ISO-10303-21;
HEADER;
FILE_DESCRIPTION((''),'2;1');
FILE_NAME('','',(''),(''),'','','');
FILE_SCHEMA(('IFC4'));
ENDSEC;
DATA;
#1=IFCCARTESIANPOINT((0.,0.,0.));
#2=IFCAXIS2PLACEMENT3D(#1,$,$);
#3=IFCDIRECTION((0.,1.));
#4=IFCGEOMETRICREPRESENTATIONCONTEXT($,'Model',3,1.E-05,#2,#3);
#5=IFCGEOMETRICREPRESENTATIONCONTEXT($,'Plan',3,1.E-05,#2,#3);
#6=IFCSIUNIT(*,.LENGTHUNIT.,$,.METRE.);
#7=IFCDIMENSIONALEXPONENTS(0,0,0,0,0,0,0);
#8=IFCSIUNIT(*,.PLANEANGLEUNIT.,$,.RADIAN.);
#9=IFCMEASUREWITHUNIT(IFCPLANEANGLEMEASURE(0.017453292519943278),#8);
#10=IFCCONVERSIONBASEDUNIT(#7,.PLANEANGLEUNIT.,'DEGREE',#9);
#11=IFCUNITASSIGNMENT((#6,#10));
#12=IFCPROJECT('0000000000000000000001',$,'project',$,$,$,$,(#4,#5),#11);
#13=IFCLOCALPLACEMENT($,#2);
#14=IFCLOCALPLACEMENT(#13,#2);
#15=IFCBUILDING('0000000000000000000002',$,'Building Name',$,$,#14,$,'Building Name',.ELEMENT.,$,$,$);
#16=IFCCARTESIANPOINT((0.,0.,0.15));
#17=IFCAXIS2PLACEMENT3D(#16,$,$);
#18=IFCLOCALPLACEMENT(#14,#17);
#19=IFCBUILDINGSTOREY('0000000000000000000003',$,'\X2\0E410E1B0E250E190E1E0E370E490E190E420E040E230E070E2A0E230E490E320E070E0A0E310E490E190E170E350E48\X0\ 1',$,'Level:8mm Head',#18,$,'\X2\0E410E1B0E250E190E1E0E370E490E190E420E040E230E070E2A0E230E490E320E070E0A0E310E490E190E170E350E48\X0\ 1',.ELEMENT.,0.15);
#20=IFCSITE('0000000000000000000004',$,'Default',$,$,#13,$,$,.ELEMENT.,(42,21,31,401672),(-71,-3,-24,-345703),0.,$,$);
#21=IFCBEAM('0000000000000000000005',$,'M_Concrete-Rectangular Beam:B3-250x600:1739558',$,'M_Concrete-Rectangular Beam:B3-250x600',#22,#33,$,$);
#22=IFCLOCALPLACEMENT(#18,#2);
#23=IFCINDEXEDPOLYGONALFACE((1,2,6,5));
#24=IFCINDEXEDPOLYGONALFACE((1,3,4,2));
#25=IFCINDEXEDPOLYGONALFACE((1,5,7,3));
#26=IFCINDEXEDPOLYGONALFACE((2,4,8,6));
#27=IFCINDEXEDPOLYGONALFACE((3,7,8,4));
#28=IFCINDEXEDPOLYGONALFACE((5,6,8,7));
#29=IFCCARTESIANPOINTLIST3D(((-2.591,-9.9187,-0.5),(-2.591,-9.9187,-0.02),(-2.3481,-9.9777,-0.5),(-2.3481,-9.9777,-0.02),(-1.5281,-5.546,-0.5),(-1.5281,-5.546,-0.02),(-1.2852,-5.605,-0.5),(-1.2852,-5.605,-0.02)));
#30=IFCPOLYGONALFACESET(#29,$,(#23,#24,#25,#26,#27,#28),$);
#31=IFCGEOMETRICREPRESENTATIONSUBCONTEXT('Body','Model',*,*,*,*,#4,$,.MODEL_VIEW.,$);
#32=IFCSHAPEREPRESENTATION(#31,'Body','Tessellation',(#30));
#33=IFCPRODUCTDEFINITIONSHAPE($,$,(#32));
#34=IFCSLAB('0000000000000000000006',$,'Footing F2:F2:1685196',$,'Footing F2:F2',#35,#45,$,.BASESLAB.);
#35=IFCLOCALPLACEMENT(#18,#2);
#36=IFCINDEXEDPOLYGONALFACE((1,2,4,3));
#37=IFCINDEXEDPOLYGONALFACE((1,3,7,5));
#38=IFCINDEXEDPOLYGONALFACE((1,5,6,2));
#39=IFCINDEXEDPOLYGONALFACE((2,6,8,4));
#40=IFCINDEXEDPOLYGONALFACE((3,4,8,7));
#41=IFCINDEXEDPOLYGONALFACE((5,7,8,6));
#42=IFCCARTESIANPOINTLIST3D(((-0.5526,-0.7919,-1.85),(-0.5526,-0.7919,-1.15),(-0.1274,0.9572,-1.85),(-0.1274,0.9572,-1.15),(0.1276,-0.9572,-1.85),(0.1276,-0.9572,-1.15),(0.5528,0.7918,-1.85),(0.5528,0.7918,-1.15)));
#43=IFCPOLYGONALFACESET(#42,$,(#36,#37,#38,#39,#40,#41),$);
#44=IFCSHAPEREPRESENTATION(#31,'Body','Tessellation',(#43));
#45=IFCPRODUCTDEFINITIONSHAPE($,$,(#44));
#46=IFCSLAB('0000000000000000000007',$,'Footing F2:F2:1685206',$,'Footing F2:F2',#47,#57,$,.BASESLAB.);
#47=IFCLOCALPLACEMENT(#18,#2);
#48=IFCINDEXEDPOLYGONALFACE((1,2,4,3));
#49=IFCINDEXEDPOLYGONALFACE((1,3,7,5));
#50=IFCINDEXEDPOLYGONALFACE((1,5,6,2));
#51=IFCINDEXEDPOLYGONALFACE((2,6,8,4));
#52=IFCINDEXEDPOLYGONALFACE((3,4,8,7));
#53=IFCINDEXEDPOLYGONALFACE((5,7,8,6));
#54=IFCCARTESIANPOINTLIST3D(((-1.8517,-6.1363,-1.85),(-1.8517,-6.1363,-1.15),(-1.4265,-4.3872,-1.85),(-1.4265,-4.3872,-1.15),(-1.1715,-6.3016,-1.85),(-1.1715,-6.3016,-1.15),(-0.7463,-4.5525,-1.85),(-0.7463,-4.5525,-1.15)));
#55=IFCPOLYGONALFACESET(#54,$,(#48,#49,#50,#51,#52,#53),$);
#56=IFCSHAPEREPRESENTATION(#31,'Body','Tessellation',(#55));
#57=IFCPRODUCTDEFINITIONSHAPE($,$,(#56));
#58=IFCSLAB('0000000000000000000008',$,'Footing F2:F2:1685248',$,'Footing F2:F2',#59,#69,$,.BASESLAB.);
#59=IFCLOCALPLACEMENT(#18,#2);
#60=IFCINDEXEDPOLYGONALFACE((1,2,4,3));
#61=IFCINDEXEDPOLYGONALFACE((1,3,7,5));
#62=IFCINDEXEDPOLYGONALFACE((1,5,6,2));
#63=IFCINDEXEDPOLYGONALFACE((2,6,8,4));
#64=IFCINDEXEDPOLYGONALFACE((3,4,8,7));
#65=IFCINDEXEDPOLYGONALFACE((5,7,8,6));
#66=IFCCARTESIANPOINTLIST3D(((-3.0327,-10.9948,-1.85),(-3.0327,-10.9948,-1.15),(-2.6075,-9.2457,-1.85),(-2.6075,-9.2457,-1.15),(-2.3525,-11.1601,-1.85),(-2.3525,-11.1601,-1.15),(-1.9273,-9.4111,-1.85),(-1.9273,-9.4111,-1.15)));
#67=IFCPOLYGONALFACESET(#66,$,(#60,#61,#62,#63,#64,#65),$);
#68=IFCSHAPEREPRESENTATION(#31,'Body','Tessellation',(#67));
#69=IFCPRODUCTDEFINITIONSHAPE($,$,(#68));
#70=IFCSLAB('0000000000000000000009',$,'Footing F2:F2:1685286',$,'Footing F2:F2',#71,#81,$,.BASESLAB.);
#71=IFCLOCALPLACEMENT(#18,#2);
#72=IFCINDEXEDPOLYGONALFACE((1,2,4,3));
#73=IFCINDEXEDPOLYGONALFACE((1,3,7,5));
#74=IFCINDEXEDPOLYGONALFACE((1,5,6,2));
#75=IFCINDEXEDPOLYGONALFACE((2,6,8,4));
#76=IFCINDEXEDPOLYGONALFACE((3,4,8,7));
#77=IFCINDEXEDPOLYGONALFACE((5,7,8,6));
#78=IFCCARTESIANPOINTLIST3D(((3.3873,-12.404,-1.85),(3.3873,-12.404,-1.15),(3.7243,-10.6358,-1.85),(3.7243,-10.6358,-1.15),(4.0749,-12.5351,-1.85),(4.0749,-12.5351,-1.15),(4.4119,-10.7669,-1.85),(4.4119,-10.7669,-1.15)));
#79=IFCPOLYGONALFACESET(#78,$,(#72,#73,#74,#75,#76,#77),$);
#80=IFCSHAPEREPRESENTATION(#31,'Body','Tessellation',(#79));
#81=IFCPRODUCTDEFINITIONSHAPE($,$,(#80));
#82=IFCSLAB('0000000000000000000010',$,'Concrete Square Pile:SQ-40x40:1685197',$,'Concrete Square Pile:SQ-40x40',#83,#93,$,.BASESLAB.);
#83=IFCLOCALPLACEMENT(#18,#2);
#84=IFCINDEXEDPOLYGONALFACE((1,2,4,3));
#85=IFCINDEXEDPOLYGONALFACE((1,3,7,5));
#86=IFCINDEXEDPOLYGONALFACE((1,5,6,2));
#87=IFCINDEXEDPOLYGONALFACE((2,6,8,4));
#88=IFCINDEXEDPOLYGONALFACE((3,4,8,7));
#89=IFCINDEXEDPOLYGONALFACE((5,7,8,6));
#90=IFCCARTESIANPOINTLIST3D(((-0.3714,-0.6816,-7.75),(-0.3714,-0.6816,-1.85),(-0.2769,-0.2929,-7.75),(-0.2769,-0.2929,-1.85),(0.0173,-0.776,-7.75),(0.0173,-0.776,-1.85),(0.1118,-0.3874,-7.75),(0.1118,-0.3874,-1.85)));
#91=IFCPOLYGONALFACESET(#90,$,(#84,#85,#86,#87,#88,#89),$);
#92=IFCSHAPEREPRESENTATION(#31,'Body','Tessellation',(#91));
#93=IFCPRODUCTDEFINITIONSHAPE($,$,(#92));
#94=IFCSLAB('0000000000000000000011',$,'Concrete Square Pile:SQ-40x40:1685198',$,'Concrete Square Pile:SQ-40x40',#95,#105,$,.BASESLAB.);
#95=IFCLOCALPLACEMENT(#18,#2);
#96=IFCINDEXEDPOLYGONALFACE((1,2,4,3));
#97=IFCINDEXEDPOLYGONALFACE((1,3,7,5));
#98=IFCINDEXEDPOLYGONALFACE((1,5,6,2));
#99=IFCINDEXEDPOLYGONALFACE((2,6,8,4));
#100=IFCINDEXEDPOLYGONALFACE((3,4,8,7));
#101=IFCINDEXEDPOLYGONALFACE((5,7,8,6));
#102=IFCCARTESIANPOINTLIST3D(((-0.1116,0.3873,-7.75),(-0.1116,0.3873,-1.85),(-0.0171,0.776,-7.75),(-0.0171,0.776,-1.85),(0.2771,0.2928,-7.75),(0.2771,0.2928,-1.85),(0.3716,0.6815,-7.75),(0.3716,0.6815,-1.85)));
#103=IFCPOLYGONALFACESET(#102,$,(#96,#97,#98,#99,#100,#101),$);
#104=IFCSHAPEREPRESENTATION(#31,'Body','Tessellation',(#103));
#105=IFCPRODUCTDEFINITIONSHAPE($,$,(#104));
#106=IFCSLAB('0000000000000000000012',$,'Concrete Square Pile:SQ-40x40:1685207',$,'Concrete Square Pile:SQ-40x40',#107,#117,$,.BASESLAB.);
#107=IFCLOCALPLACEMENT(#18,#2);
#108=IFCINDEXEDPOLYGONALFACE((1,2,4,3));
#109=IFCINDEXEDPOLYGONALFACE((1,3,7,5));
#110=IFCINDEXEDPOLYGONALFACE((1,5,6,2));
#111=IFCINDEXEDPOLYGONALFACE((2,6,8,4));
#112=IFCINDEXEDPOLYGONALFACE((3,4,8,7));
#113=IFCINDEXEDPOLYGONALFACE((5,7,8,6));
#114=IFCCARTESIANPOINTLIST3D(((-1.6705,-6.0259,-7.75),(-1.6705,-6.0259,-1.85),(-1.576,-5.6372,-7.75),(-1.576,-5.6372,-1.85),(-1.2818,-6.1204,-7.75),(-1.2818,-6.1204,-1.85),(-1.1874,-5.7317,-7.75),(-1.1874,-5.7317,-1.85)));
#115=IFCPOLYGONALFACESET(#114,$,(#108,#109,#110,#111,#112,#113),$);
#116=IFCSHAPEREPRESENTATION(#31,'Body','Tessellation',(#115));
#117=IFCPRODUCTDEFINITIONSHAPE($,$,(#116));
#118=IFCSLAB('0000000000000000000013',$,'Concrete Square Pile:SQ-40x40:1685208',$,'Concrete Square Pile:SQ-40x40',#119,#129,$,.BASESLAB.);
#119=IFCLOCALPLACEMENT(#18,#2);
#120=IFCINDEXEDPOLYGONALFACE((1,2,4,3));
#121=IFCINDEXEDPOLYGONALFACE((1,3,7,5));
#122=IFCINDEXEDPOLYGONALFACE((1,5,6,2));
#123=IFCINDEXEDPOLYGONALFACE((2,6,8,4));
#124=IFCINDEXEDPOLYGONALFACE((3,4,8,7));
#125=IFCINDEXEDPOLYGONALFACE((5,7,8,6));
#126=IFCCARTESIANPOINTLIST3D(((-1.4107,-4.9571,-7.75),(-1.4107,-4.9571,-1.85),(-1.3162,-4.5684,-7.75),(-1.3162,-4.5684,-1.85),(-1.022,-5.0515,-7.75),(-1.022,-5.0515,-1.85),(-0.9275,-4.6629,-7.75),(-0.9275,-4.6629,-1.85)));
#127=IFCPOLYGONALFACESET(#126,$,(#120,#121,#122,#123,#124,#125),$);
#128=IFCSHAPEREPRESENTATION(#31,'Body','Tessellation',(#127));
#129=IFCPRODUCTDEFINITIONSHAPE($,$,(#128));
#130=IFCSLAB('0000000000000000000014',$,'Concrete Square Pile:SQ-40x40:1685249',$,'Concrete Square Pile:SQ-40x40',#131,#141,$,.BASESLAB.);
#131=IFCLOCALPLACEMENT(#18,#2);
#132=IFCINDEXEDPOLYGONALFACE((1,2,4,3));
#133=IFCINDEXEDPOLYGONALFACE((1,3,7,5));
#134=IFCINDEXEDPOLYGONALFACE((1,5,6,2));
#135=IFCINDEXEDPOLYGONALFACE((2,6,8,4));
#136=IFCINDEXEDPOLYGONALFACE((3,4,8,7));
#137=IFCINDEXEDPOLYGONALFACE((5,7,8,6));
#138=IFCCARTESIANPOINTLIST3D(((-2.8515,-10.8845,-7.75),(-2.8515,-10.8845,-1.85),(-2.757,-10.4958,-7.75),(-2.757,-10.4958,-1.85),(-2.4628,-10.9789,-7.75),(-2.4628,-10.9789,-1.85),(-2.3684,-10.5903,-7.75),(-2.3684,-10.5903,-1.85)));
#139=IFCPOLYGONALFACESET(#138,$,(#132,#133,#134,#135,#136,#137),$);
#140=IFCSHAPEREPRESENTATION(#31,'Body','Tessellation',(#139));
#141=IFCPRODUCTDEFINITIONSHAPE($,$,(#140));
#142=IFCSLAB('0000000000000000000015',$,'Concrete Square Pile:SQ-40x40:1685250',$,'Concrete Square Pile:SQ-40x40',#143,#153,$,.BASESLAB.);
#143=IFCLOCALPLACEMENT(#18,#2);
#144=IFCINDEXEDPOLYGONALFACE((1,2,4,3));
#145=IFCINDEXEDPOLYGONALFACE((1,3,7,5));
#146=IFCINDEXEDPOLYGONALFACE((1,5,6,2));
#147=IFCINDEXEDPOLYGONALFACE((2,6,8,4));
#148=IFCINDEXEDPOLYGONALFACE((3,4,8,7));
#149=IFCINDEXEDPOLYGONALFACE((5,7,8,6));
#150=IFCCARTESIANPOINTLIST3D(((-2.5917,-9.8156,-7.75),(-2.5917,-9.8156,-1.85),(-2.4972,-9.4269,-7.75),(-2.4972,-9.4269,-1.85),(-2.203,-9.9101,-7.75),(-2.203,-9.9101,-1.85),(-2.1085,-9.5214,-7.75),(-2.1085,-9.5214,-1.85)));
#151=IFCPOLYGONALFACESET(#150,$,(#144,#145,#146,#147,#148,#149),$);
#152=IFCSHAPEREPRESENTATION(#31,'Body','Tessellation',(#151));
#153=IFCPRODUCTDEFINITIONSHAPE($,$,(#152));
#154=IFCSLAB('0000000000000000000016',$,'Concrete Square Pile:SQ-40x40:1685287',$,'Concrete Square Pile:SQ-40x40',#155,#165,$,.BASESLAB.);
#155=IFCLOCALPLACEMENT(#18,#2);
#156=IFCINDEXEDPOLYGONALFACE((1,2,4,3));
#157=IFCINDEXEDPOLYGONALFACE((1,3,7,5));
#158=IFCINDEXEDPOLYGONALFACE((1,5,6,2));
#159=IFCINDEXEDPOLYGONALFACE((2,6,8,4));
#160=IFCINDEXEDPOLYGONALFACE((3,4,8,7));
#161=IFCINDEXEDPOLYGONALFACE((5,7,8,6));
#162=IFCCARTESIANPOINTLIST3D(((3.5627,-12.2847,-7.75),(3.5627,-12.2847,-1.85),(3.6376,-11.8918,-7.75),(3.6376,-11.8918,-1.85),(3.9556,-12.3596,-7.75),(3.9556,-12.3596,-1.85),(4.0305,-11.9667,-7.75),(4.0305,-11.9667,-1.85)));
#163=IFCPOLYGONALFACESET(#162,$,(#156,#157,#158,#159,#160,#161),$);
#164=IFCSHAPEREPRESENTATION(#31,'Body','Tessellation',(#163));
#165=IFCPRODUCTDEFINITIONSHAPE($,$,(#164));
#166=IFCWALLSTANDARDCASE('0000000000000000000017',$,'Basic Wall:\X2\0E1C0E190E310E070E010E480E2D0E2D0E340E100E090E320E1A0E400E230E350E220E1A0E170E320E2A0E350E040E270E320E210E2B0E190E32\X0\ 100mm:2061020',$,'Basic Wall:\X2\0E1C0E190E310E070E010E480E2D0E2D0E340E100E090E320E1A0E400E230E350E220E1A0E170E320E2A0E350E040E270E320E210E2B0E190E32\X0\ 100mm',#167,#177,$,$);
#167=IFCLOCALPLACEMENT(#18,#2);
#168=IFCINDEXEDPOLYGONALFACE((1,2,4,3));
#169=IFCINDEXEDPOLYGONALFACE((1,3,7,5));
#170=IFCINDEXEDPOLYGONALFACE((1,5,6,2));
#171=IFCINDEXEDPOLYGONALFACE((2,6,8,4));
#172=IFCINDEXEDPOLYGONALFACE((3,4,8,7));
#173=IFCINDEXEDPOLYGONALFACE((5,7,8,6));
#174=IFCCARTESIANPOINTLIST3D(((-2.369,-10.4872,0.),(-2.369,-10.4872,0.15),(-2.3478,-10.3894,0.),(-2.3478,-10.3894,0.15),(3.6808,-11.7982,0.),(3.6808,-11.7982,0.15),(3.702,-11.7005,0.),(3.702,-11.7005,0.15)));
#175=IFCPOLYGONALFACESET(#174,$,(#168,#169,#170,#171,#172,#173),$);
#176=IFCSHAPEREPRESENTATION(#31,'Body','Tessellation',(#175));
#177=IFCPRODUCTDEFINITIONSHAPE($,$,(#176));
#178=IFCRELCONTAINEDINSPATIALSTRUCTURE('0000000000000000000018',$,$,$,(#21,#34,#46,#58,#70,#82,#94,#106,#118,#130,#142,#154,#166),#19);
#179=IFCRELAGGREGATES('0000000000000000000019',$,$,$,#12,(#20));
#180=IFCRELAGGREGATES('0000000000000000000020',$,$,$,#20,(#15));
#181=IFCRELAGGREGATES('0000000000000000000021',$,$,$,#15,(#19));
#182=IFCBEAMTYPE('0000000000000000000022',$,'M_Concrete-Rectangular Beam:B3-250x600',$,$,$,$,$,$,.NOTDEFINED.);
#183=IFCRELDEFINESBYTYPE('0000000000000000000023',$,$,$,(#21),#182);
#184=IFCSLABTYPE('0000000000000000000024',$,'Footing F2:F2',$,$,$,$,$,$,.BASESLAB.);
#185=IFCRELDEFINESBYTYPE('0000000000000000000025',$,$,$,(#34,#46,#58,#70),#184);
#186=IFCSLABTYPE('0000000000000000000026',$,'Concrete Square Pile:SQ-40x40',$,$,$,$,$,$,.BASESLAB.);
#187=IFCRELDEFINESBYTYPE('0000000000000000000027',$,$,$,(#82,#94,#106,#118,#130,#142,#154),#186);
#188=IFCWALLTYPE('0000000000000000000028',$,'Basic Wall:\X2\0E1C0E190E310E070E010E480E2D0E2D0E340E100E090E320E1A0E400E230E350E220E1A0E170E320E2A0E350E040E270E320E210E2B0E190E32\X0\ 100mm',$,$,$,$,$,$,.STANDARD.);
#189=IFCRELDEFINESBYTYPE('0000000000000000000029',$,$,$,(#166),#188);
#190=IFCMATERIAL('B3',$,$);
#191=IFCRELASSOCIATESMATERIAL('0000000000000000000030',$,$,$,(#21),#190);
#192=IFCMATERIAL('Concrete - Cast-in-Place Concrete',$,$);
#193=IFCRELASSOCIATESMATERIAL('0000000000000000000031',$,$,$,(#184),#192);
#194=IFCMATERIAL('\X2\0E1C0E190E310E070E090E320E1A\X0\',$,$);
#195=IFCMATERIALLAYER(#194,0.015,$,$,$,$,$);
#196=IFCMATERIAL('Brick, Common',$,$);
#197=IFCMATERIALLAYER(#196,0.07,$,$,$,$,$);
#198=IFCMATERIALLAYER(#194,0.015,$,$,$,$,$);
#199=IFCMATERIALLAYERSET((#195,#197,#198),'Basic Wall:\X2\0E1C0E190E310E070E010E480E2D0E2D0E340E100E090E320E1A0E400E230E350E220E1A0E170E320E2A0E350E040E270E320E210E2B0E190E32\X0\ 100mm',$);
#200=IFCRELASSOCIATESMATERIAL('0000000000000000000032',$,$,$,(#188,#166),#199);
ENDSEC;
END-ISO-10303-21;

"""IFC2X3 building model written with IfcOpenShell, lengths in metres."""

from ifc_helpers import new_model, entity, si_unit, converted_unit, direction, frame, frame_2d, origin, origin_2d_with_axis, place, context, subcontext, project, spatial, rectangle, extrude, clip, halfspace, material, layer, layer_set, layer_usage, type_object, element, save


model = new_model("IFC2X3")

# Units and contexts
model_context = context("Model", 3, precision=1e-05, world=origin(), true_north=direction((0.0, 1.0)))
plan_context = context("Plan", 3, precision=1e-05, world=origin(), true_north=direction((0.0, 1.0)))
body_context = subcontext(model_context, "Body", "Model", "MODEL_VIEW")
ifc_project = project(units=[si_unit("LENGTHUNIT", "METRE"), converted_unit("PLANEANGLEUNIT", "DEGREE", entity("IfcPlaneAngleMeasure", 0.017453292519943278), si_unit("PLANEANGLEUNIT", "RADIAN"), dimensions=[0, 0, 0, 0, 0, 0, 0])], contexts=[model_context, plan_context])

# Site, building, storey
site_placement = place(None, origin())
site = spatial("IfcSite", under=ifc_project, at=site_placement, Name="Default", CompositionType="ELEMENT", RefLatitude=(42, 21, 31, 401672), RefLongitude=(-71, -3, -24, -345703), RefElevation=0.0)
building_placement = place(site_placement, origin())
building = spatial("IfcBuilding", under=site, at=building_placement, Name="Building Name", LongName="Building Name", CompositionType="ELEMENT")
storey_placement = place(building_placement, frame((0.0, 0.0, 0.15)))
storey = spatial("IfcBuildingStorey", under=building, at=storey_placement, Name="แปลนพื้นโครงสร้างชั้นที่ 1", ObjectType="Level:8mm Head", LongName="แปลนพื้นโครงสร้างชั้นที่ 1", CompositionType="ELEMENT", Elevation=0.15)

# Beam
ifc_material_1 = material(Name="B3")
beam_type_1 = type_object("IfcBeamType", Name="M_Concrete-Rectangular Beam:B3-250x600", PredefinedType="NOTDEFINED")
beam_1_placement = place(storey_placement, frame((-2.6501, -10.1616, 0.0), z_axis=(0.0, 0.0, 1.0), x_axis=(0.236201, 0.971704, 0.0)))
element("IfcBeam", 1, at=beam_1_placement, inside=storey, type_object=beam_type_1, material=ifc_material_1, Name="M_Concrete-Rectangular Beam:B3-250x600:1739558", ObjectType="M_Concrete-Rectangular Beam:B3-250x600", context=body_context, shape_type="SweptSolid", body=[
    extrude(rectangle(XDim=0.48, YDim=0.25, at=frame_2d((0.0, 0.0), x_axis=(1.0, 0.0))), frame((0.25, -0.125, -0.26), z_axis=(1.0, 0.0, 0.0), x_axis=(0.0, 0.0, -1.0)), (0.0, 0.0, 1.0), 4.5),
])

# Slabs
ifc_material_2 = material(Name="Concrete - Cast-in-Place Concrete")
slab_type_1 = type_object("IfcSlabType", Name="Footing F2:F2", PredefinedType="BASESLAB", material=ifc_material_2)
slab_1_placement = place(storey_placement, origin())
element("IfcSlab", 2, at=slab_1_placement, inside=storey, type_object=slab_type_1, Name="Footing F2:F2:1685196", ObjectType="Footing F2:F2", PredefinedType="BASESLAB", context=body_context, shape_type="SweptSolid", body=[
    extrude(rectangle(XDim=1.8, YDim=0.7, at=origin_2d_with_axis()), frame((0.0001, 0.0, -1.85), z_axis=(0.0, 0.0, 1.0), x_axis=(-0.236201, -0.971704, 0.0)), (0.0, 0.0, 1.0), 0.7),
])
slab_2_placement = place(storey_placement, origin())
element("IfcSlab", 3, at=slab_2_placement, inside=storey, type_object=slab_type_1, Name="Footing F2:F2:1685206", ObjectType="Footing F2:F2", PredefinedType="BASESLAB", context=body_context, shape_type="SweptSolid", body=[
    extrude(rectangle(XDim=1.8, YDim=0.7, at=frame_2d((0.0, 0.0), x_axis=(1.0, 0.0))), frame((-1.299, -5.3444, -1.85), z_axis=(0.0, 0.0, 1.0), x_axis=(-0.236201, -0.971704, 0.0)), (0.0, 0.0, 1.0), 0.7),
])
slab_3_placement = place(storey_placement, origin())
element("IfcSlab", 4, at=slab_3_placement, inside=storey, type_object=slab_type_1, Name="Footing F2:F2:1685248", ObjectType="Footing F2:F2", PredefinedType="BASESLAB", context=body_context, shape_type="SweptSolid", body=[
    extrude(rectangle(XDim=1.8, YDim=0.7, at=frame_2d((0.0, 0.0), x_axis=(1.0, 0.0))), frame((-2.48, -10.2029, -1.85), z_axis=(0.0, 0.0, 1.0), x_axis=(-0.236201, -0.971704, 0.0)), (0.0, 0.0, 1.0), 0.7),
])
slab_4_placement = place(storey_placement, origin())
element("IfcSlab", 5, at=slab_4_placement, inside=storey, type_object=slab_type_1, Name="Footing F2:F2:1685286", ObjectType="Footing F2:F2", PredefinedType="BASESLAB", context=body_context, shape_type="SweptSolid", body=[
    extrude(rectangle(XDim=1.8, YDim=0.7, at=frame_2d((0.0, 0.0), x_axis=(1.0, 0.0))), frame((3.8996, -11.5855, -1.85), z_axis=(0.0, 0.0, 1.0), x_axis=(-0.187257, -0.982311, 0.0)), (0.0, 0.0, 1.0), 0.7),
])
slab_type_2 = type_object("IfcSlabType", Name="Concrete Square Pile:SQ-40x40", PredefinedType="BASESLAB")
slab_5_placement = place(storey_placement, origin())
element("IfcSlab", 6, at=slab_5_placement, inside=storey, type_object=slab_type_2, Name="Concrete Square Pile:SQ-40x40:1685197", ObjectType="Concrete Square Pile:SQ-40x40", PredefinedType="BASESLAB", context=body_context, shape_type="SweptSolid", body=[
    extrude(rectangle(XDim=0.4, YDim=0.4, at=frame_2d((0.0, 0.0), x_axis=(1.0, 0.0))), frame((-0.1298, -0.5345, -7.75), z_axis=(0.0, 0.0, 1.0), x_axis=(-0.236201, -0.971704, 0.0)), (0.0, 0.0, 1.0), 5.9),
])
slab_6_placement = place(storey_placement, origin())
element("IfcSlab", 7, at=slab_6_placement, inside=storey, type_object=slab_type_2, Name="Concrete Square Pile:SQ-40x40:1685198", ObjectType="Concrete Square Pile:SQ-40x40", PredefinedType="BASESLAB", context=body_context, shape_type="SweptSolid", body=[
    extrude(rectangle(XDim=0.4, YDim=0.4, at=frame_2d((0.0, 0.0), x_axis=(1.0, 0.0))), frame((0.13, 0.5344, -7.75), z_axis=(0.0, 0.0, 1.0), x_axis=(-0.236201, -0.971704, 0.0)), (0.0, 0.0, 1.0), 5.9),
])
slab_7_placement = place(storey_placement, origin())
element("IfcSlab", 8, at=slab_7_placement, inside=storey, type_object=slab_type_2, Name="Concrete Square Pile:SQ-40x40:1685207", ObjectType="Concrete Square Pile:SQ-40x40", PredefinedType="BASESLAB", context=body_context, shape_type="SweptSolid", body=[
    extrude(rectangle(XDim=0.4, YDim=0.4, at=frame_2d((0.0, 0.0), x_axis=(1.0, 0.0))), frame((-1.4289, -5.8788, -7.75), z_axis=(0.0, 0.0, 1.0), x_axis=(-0.236201, -0.971704, 0.0)), (0.0, 0.0, 1.0), 5.9),
])
slab_8_placement = place(storey_placement, origin())
element("IfcSlab", 9, at=slab_8_placement, inside=storey, type_object=slab_type_2, Name="Concrete Square Pile:SQ-40x40:1685208", ObjectType="Concrete Square Pile:SQ-40x40", PredefinedType="BASESLAB", context=body_context, shape_type="SweptSolid", body=[
    extrude(rectangle(XDim=0.4, YDim=0.4, at=frame_2d((0.0, 0.0), x_axis=(1.0, 0.0))), frame((-1.1691, -4.81, -7.75), z_axis=(0.0, 0.0, 1.0), x_axis=(-0.236201, -0.971704, 0.0)), (0.0, 0.0, 1.0), 5.9),
])
slab_9_placement = place(storey_placement, origin())
element("IfcSlab", 10, at=slab_9_placement, inside=storey, type_object=slab_type_2, Name="Concrete Square Pile:SQ-40x40:1685249", ObjectType="Concrete Square Pile:SQ-40x40", PredefinedType="BASESLAB", context=body_context, shape_type="SweptSolid", body=[
    extrude(rectangle(XDim=0.4, YDim=0.4, at=frame_2d((0.0, 0.0), x_axis=(1.0, 0.0))), frame((-2.6099, -10.7374, -7.75), z_axis=(0.0, 0.0, 1.0), x_axis=(-0.236201, -0.971704, 0.0)), (0.0, 0.0, 1.0), 5.9),
])
slab_10_placement = place(storey_placement, origin())
element("IfcSlab", 11, at=slab_10_placement, inside=storey, type_object=slab_type_2, Name="Concrete Square Pile:SQ-40x40:1685250", ObjectType="Concrete Square Pile:SQ-40x40", PredefinedType="BASESLAB", context=body_context, shape_type="SweptSolid", body=[
    extrude(rectangle(XDim=0.4, YDim=0.4, at=origin_2d_with_axis()), frame((-2.3501, -9.6685, -7.75), z_axis=(0.0, 0.0, 1.0), x_axis=(-0.236201, -0.971704, 0.0)), (0.0, 0.0, 1.0), 5.9),
])
slab_11_placement = place(storey_placement, origin())
element("IfcSlab", 12, at=slab_11_placement, inside=storey, type_object=slab_type_2, Name="Concrete Square Pile:SQ-40x40:1685287", ObjectType="Concrete Square Pile:SQ-40x40", PredefinedType="BASESLAB", context=body_context, shape_type="SweptSolid", body=[
    extrude(rectangle(XDim=0.4, YDim=0.4, at=frame_2d((0.0, 0.0), x_axis=(1.0, 0.0))), frame((3.7966, -12.1257, -7.75), z_axis=(0.0, 0.0, 1.0), x_axis=(-0.187257, -0.982311, 0.0)), (0.0, 0.0, 1.0), 5.9),
])

# Wall
ifc_material_3 = material(Name="ผนังฉาบ")
ifc_layer_1 = layer(ifc_material_3, 0.015)
ifc_material_4 = material(Name="Brick, Common")
ifc_layer_2 = layer(ifc_material_4, 0.07)
ifc_layer_3 = layer(ifc_material_3, 0.015)
ifc_layer_set_1 = layer_set([ifc_layer_1, ifc_layer_2, ifc_layer_3], Name="Basic Wall:ผนังก่ออิฐฉาบเรียบทาสีความหนา 100mm")
ifc_layer_usage_1 = layer_usage(ifc_layer_set_1, "AXIS2", "POSITIVE", -0.05)
wall_type_1 = type_object("IfcWallType", Name="Basic Wall:ผนังก่ออิฐฉาบเรียบทาสีความหนา 100mm", PredefinedType="STANDARD", material=ifc_layer_set_1)
wall_1_placement = place(storey_placement, frame((-2.3584, -10.4383, 0.0), z_axis=(0.0, 0.0, 1.0), x_axis=(0.977314, -0.211795, 0.0)))
element("IfcWallStandardCase", 13, at=wall_1_placement, inside=storey, type_object=wall_type_1, material=ifc_layer_usage_1, Name="Basic Wall:ผนังก่ออิฐฉาบเรียบทาสีความหนา 100mm:2061020", ObjectType="Basic Wall:ผนังก่ออิฐฉาบเรียบทาสีความหนา 100mm", context=body_context, shape_type="Clipping", body=[
    clip(extrude(rectangle(XDim=6.1902, YDim=0.1, at=frame_2d((3.0951, 0.0), x_axis=(-1.0, 0.0))), origin(), (0.0, 0.0, 1.0), 0.15), halfspace(origin(), True)),
])

save(model, "model.ifc")
